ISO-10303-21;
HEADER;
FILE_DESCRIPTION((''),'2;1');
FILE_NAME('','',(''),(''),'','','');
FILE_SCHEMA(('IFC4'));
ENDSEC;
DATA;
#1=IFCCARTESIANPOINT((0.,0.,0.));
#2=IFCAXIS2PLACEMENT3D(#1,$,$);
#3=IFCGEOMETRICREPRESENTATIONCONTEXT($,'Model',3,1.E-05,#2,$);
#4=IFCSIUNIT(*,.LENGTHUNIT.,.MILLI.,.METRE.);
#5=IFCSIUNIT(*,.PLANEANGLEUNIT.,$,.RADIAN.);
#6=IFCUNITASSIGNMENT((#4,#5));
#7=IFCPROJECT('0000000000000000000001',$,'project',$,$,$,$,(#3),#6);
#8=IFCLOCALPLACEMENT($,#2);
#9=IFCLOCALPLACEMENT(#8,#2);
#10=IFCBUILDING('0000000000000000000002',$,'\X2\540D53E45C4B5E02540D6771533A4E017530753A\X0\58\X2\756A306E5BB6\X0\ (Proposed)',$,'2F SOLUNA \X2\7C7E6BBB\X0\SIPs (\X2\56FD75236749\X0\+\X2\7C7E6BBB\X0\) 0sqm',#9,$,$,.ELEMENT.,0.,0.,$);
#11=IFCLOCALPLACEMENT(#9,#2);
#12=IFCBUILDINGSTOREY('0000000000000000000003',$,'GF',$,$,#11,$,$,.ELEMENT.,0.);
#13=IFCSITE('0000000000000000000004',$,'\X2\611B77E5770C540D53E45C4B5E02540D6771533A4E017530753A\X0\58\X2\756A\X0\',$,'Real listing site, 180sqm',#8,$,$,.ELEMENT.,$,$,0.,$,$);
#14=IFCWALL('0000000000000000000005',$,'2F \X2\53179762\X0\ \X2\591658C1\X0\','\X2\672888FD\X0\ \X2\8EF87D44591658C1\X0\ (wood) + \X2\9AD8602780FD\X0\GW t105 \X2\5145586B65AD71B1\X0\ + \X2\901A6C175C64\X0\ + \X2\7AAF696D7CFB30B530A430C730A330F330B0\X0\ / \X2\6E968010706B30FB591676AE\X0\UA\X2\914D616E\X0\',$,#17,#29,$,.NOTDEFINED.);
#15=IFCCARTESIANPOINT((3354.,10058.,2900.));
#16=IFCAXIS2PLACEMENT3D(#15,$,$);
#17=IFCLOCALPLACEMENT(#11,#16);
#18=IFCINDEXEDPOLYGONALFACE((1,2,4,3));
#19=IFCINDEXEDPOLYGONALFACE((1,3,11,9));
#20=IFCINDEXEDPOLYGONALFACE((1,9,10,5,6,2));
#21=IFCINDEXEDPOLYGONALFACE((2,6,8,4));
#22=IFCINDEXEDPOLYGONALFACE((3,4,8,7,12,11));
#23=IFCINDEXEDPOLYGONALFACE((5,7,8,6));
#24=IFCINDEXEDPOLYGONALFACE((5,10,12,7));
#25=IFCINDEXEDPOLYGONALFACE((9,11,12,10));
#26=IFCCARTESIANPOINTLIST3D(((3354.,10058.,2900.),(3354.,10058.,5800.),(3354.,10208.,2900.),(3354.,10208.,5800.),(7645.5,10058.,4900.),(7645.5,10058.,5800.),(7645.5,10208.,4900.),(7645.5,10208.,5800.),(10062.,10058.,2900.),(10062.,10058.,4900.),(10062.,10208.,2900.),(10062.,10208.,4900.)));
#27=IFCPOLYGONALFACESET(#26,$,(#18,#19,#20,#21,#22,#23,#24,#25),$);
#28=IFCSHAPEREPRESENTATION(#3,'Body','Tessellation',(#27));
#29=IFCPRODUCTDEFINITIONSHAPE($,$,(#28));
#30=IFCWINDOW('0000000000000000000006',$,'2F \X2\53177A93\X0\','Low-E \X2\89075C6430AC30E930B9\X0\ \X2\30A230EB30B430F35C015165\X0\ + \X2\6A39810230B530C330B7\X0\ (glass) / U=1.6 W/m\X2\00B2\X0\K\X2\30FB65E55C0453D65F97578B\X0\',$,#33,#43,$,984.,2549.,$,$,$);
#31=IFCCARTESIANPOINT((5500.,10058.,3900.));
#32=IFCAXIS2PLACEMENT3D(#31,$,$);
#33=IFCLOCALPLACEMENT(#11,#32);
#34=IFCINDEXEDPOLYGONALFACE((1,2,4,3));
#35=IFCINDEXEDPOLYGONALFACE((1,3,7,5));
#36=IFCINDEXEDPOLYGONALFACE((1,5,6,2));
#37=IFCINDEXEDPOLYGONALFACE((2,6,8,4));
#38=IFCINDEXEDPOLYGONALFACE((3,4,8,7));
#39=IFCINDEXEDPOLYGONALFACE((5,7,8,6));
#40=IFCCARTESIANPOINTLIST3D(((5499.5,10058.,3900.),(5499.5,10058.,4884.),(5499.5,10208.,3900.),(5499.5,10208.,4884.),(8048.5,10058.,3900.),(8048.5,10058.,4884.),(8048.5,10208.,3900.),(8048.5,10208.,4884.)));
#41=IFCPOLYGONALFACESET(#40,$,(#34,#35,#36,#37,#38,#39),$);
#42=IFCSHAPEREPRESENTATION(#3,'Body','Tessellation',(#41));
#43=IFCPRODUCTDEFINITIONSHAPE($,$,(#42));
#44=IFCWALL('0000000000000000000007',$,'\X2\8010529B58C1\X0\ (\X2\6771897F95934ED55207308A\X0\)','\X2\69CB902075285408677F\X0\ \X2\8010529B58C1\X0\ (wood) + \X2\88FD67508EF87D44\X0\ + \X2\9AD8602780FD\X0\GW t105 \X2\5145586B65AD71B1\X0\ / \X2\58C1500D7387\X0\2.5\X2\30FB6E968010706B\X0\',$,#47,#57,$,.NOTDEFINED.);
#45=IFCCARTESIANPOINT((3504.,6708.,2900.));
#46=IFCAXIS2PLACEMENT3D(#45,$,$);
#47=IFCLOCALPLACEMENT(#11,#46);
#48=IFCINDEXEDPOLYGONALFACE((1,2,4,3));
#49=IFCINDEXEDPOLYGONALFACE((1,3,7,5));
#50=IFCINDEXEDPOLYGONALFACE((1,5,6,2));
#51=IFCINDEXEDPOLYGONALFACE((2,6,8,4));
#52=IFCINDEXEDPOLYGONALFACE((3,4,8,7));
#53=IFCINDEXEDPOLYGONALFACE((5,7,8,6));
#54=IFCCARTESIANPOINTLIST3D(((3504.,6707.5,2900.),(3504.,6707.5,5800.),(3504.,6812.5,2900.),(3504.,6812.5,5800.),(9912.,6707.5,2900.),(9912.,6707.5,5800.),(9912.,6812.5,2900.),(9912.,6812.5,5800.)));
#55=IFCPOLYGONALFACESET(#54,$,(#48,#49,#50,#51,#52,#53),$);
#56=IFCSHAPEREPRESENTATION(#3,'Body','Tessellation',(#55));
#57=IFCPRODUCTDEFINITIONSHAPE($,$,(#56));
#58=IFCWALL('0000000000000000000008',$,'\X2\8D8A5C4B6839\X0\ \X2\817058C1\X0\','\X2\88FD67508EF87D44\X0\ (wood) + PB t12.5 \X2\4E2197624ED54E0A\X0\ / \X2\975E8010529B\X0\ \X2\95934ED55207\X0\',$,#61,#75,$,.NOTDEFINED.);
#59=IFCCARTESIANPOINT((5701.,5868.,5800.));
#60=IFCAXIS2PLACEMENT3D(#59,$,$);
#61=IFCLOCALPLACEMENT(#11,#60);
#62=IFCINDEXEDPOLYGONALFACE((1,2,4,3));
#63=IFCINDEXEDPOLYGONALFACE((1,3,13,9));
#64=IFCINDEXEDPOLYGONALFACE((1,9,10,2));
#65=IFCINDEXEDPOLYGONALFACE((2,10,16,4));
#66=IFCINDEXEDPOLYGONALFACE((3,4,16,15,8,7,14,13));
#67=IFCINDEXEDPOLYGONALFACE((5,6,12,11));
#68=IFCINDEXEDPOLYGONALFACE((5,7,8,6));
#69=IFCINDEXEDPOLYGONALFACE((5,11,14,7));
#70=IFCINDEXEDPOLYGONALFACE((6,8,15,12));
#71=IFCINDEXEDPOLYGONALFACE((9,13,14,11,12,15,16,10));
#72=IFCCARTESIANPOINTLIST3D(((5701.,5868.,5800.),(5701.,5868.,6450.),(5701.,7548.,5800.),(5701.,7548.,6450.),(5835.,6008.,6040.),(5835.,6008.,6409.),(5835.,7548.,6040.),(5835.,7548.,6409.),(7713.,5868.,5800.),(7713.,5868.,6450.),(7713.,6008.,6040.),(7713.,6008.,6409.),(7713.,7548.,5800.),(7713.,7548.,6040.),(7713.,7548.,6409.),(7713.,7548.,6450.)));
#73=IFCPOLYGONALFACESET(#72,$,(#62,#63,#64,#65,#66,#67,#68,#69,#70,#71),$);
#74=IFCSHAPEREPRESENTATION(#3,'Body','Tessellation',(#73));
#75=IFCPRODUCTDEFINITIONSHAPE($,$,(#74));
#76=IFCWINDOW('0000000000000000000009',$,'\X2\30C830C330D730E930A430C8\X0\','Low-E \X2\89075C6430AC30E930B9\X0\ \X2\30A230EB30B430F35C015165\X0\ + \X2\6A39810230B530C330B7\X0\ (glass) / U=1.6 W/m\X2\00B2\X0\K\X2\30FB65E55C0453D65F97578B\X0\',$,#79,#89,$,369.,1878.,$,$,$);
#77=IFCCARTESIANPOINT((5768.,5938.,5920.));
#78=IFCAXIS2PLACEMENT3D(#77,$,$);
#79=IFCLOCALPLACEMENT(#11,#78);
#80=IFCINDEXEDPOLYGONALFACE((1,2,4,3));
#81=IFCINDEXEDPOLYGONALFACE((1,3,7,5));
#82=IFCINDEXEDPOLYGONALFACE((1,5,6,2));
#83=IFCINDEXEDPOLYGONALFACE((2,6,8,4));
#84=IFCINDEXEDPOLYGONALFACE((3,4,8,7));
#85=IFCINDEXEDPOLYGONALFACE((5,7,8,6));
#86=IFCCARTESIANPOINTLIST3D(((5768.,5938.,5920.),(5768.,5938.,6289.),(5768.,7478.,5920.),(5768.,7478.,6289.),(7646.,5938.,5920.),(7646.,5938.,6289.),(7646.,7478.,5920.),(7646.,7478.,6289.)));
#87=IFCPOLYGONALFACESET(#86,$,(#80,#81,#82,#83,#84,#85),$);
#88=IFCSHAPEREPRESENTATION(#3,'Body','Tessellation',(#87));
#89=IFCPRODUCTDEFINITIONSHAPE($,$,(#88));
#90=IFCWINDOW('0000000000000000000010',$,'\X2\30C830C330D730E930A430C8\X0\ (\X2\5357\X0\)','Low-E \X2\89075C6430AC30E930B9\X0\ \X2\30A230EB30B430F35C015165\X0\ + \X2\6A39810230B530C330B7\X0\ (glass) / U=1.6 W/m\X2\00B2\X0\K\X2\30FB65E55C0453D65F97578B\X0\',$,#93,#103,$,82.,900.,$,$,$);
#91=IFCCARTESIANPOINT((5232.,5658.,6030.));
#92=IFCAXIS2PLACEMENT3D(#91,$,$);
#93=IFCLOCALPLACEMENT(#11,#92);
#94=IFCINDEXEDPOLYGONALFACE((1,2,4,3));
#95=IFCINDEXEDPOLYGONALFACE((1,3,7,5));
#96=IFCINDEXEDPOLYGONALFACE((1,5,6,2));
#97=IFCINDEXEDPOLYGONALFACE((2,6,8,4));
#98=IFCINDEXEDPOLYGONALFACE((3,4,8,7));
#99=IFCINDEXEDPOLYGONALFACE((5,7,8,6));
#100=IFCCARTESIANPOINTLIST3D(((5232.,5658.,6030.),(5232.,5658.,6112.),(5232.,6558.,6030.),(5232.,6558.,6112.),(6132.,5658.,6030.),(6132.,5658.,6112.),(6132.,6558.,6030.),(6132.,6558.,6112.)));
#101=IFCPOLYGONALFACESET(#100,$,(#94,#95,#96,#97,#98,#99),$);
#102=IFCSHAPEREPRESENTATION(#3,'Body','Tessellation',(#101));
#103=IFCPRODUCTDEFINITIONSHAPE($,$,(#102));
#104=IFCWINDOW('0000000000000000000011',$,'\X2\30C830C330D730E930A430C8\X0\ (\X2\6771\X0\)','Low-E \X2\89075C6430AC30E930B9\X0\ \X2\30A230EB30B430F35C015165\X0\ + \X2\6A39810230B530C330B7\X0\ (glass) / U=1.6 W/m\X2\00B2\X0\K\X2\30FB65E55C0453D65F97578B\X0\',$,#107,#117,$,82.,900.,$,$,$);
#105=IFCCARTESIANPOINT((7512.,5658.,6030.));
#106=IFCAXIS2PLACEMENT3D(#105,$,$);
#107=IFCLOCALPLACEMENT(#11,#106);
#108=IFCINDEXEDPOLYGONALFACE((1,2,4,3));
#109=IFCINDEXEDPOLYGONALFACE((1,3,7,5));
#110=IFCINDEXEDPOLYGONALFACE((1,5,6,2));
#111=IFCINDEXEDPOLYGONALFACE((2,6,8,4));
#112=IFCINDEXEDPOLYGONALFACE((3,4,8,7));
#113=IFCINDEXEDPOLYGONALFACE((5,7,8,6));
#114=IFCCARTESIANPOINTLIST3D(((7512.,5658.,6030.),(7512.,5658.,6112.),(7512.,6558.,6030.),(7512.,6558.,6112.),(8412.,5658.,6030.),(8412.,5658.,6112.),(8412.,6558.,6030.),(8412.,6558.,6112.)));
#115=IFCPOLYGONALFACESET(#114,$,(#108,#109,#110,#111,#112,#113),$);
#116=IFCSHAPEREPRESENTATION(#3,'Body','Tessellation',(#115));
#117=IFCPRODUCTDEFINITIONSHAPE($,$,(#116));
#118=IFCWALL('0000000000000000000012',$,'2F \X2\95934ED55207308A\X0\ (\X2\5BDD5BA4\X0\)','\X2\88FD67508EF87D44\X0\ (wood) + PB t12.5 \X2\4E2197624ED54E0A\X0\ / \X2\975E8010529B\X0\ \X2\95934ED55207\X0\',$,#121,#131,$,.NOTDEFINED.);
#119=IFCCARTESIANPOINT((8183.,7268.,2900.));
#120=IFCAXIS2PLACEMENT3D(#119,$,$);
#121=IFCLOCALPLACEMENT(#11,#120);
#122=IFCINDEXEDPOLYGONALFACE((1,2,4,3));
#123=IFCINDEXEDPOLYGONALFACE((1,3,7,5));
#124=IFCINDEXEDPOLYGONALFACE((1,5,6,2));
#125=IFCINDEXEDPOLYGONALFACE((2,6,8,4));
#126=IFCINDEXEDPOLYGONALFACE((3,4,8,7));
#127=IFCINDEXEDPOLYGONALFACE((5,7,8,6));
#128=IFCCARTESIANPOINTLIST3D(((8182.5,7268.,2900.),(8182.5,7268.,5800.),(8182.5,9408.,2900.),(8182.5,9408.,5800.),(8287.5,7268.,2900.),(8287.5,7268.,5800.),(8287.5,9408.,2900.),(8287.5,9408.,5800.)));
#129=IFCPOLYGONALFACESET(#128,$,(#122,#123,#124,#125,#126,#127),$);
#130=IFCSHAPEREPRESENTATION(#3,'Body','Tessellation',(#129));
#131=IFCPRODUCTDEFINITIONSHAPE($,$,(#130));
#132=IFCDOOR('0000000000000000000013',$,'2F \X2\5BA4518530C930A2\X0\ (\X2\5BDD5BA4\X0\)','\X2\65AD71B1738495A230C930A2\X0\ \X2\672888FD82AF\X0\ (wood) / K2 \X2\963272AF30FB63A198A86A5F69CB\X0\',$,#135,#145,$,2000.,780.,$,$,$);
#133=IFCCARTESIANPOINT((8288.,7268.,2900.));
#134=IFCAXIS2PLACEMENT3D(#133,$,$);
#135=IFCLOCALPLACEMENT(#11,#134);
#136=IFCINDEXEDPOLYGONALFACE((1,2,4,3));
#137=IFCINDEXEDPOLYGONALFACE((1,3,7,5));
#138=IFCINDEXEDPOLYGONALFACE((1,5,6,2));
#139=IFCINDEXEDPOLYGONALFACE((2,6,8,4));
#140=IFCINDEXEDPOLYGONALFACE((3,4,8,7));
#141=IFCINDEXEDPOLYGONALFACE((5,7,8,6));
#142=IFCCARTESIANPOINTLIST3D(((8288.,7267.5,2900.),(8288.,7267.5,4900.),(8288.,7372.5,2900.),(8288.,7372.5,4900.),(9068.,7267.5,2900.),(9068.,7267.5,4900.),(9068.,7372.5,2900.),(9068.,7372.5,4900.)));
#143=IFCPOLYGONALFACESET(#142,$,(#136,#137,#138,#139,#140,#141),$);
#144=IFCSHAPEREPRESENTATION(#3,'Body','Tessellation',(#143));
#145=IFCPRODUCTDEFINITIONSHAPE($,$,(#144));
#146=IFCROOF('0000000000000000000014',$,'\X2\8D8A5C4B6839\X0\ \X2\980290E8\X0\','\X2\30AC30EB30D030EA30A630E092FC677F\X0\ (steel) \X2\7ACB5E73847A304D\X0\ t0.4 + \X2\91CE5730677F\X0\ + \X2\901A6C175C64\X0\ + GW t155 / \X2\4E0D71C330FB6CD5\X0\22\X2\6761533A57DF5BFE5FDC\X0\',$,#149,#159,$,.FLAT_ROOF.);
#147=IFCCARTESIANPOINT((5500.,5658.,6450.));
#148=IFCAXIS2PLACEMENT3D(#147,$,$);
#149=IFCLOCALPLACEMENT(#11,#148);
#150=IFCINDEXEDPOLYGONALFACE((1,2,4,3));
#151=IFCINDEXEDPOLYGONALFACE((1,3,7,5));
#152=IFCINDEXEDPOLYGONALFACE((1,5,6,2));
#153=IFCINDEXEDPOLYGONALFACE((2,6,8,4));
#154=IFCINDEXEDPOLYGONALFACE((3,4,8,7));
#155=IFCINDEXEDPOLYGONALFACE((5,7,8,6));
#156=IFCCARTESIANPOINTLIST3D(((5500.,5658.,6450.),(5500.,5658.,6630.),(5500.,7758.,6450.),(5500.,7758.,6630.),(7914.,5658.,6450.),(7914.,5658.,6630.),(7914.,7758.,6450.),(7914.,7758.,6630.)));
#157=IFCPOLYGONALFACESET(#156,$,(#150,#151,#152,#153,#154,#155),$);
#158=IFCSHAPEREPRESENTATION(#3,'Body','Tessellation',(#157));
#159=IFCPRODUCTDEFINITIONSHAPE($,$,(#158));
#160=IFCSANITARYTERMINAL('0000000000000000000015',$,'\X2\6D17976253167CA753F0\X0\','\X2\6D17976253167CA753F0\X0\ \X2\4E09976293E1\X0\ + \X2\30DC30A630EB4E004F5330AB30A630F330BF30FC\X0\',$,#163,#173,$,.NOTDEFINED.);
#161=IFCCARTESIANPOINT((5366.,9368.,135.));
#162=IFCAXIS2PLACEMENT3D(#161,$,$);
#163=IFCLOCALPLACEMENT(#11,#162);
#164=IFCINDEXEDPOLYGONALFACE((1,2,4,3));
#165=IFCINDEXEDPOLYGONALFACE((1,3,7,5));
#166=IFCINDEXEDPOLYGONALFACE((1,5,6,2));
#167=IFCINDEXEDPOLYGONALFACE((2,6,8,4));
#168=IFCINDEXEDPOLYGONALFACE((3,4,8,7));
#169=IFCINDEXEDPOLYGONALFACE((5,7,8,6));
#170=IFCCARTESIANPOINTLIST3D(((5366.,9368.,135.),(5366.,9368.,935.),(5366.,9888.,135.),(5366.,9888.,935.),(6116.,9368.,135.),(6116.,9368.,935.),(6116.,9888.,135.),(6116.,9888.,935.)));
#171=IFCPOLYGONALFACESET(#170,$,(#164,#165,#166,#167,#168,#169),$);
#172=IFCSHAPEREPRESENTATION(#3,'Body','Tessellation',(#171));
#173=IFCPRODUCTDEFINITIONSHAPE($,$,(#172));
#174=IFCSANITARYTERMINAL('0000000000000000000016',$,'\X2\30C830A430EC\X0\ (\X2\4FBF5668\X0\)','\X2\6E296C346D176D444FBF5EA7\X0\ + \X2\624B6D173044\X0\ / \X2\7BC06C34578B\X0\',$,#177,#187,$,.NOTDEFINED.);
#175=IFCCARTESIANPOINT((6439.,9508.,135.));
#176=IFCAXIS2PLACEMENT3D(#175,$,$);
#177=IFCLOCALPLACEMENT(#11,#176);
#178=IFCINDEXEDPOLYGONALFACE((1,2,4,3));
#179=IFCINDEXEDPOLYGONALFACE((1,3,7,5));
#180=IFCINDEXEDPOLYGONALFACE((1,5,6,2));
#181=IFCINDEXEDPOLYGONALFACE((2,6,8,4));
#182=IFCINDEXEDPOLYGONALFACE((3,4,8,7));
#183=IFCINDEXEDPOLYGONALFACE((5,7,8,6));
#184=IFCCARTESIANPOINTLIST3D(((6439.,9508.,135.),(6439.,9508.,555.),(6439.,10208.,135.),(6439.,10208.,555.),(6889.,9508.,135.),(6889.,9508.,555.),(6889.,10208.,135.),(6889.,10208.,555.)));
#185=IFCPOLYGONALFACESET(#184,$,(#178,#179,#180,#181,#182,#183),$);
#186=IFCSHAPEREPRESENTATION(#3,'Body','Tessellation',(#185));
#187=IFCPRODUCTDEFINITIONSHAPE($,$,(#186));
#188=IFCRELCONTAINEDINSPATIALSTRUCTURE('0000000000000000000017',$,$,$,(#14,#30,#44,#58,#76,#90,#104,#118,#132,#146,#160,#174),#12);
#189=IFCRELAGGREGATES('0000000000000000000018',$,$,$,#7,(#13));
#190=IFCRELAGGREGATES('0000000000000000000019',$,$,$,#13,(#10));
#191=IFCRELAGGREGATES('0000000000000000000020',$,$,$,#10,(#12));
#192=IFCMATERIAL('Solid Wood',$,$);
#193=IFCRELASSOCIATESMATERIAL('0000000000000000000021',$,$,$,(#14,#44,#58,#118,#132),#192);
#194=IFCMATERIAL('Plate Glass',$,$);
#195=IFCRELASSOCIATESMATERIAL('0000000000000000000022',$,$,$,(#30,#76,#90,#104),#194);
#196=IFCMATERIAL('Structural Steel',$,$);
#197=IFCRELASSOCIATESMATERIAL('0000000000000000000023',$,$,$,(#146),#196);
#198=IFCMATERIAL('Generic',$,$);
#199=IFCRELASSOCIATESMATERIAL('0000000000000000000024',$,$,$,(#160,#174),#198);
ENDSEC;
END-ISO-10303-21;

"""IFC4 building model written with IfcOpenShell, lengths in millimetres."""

from ifc_helpers import new_model, si_unit, frame, frame_2d, origin, place, context, project, spatial, rectangle, extrude, material, element, fill, save


model = new_model("IFC4")

# Units and contexts
model_context = context("Model", 3, precision=1e-05, world=origin())
ifc_project = project(units=[si_unit("LENGTHUNIT", "METRE", prefix="MILLI"), si_unit("PLANEANGLEUNIT", "RADIAN")], contexts=[model_context])

# Site, building, storey
site_placement = place(None, origin())
site = spatial("IfcSite", under=ifc_project, at=site_placement, Name="愛知県名古屋市名東区丁田町58番", ObjectType="Real listing site, 180sqm", CompositionType="ELEMENT", RefElevation=0.0)
building_placement = place(site_placement, origin())
building = spatial("IfcBuilding", under=site, at=building_placement, Name="名古屋市名東区丁田町58番の家 (Proposed)", ObjectType="2F SOLUNA 籾殻SIPs (国産杉+籾殻) 0sqm", CompositionType="ELEMENT", ElevationOfRefHeight=0.0, ElevationOfTerrain=0.0)
storey_placement = place(building_placement, origin())
storey = spatial("IfcBuildingStorey", under=building, at=storey_placement, Name="GF", CompositionType="ELEMENT", Elevation=0.0)

# Wall, opening, window
ifc_material_1 = material(Name="Solid Wood")
wall_1_placement = place(storey_placement, frame((3354.0, 10058.0, 2900.0)))
wall_1 = element("IfcWall", 1, at=wall_1_placement, inside=storey, material=ifc_material_1, Name="2F 北面 外壁", Description="木製 軸組外壁 (wood) + 高性能GW t105 充填断熱 + 通気層 + 窯業系サイディング / 準耐火・外皮UA配慮", PredefinedType="NOTDEFINED", context=model_context, shape_type="SweptSolid", body=[
    extrude(rectangle(XDim=6708.0, YDim=150.0, at=frame_2d((3354.0, 75.0))), frame((3354.0, 10058.0, 2900.0)), (0.0, 0.0, 1.0), 2900.0),
])
opening_1_placement = place(storey_placement, frame((5500.0, 10058.0, 3900.0)))
opening_1 = element("IfcOpeningElement", 2, at=opening_1_placement, cuts=wall_1, PredefinedType="NOTDEFINED", context=model_context, shape_type="SweptSolid", body=[
    extrude(rectangle(XDim=2549.0, YDim=150.0, at=frame_2d((1274.0, 75.0))), frame((5500.0, 10058.0, 3900.0)), (0.0, 0.0, 1.0), 984.0),
])
ifc_material_2 = material(Name="Plate Glass")
window_1_placement = place(storey_placement, frame((5500.0, 10058.0, 3900.0)))
window_1 = element("IfcWindow", 3, at=window_1_placement, inside=storey, material=ifc_material_2, Name="2F 北窓", Description="Low-E 複層ガラス アルゴン封入 + 樹脂サッシ (glass) / U=1.6 W/m²K・日射取得型", OverallHeight=984.0, OverallWidth=2549.0, context=model_context, shape_type="SweptSolid", body=[
    extrude(rectangle(XDim=2549.0, YDim=150.0, at=frame_2d((1274.0, 75.0))), frame((5500.0, 10058.0, 3900.0)), (0.0, 0.0, 1.0), 984.0),
])
fill(opening_1, window_1)

# Wall
wall_2_placement = place(storey_placement, frame((3504.0, 6708.0, 2900.0)))
element("IfcWall", 4, at=wall_2_placement, inside=storey, material=ifc_material_1, Name="耐力壁 (東西間仕切り)", Description="構造用合板 耐力壁 (wood) + 製材軸組 + 高性能GW t105 充填断熱 / 壁倍率2.5・準耐火", PredefinedType="NOTDEFINED", context=model_context, shape_type="SweptSolid", body=[
    extrude(rectangle(XDim=6408.0, YDim=105.0, at=frame_2d((3204.0, 52.0))), frame((3504.0, 6708.0, 2900.0)), (0.0, 0.0, 1.0), 2900.0),
])

# Wall, openings, windows
wall_3_placement = place(storey_placement, frame((5701.0, 5868.0, 5800.0)))
wall_3 = element("IfcWall", 5, at=wall_3_placement, inside=storey, material=ifc_material_1, Name="越屋根 腰壁", Description="製材軸組 (wood) + PB t12.5 両面仕上 / 非耐力 間仕切", PredefinedType="NOTDEFINED", context=model_context, shape_type="SweptSolid", body=[
    extrude(rectangle(XDim=2012.0, YDim=1680.0, at=frame_2d((1006.0, 840.0))), frame((5701.0, 5868.0, 5800.0)), (0.0, 0.0, 1.0), 650.0),
])
opening_2_placement = place(storey_placement, frame((5768.0, 5938.0, 5920.0)))
opening_2 = element("IfcOpeningElement", 6, at=opening_2_placement, cuts=wall_3, PredefinedType="NOTDEFINED", context=model_context, shape_type="SweptSolid", body=[
    extrude(rectangle(XDim=1878.0, YDim=1540.0, at=frame_2d((939.0, 770.0))), frame((5768.0, 5938.0, 5920.0)), (0.0, 0.0, 1.0), 369.0),
])
opening_3_placement = place(storey_placement, frame((5232.0, 5658.0, 6030.0)))
opening_3 = element("IfcOpeningElement", 7, at=opening_3_placement, cuts=wall_3, PredefinedType="NOTDEFINED", context=model_context, shape_type="SweptSolid", body=[
    extrude(rectangle(XDim=900.0, YDim=900.0, at=frame_2d((450.0, 450.0))), frame((5232.0, 5658.0, 6030.0)), (0.0, 0.0, 1.0), 82.0),
])
opening_4_placement = place(storey_placement, frame((7512.0, 5658.0, 6030.0)))
opening_4 = element("IfcOpeningElement", 8, at=opening_4_placement, cuts=wall_3, PredefinedType="NOTDEFINED", context=model_context, shape_type="SweptSolid", body=[
    extrude(rectangle(XDim=900.0, YDim=900.0, at=frame_2d((450.0, 450.0))), frame((7512.0, 5658.0, 6030.0)), (0.0, 0.0, 1.0), 82.0),
])
window_2_placement = place(storey_placement, frame((5768.0, 5938.0, 5920.0)))
window_2 = element("IfcWindow", 9, at=window_2_placement, inside=storey, material=ifc_material_2, Name="トップライト", Description="Low-E 複層ガラス アルゴン封入 + 樹脂サッシ (glass) / U=1.6 W/m²K・日射取得型", OverallHeight=369.0, OverallWidth=1878.0, context=model_context, shape_type="SweptSolid", body=[
    extrude(rectangle(XDim=1878.0, YDim=1540.0, at=frame_2d((939.0, 770.0))), frame((5768.0, 5938.0, 5920.0)), (0.0, 0.0, 1.0), 369.0),
])
fill(opening_2, window_2)
window_3_placement = place(storey_placement, frame((5232.0, 5658.0, 6030.0)))
window_3 = element("IfcWindow", 10, at=window_3_placement, inside=storey, material=ifc_material_2, Name="トップライト (南)", Description="Low-E 複層ガラス アルゴン封入 + 樹脂サッシ (glass) / U=1.6 W/m²K・日射取得型", OverallHeight=82.0, OverallWidth=900.0, context=model_context, shape_type="SweptSolid", body=[
    extrude(rectangle(XDim=900.0, YDim=900.0, at=frame_2d((450.0, 450.0))), frame((5232.0, 5658.0, 6030.0)), (0.0, 0.0, 1.0), 82.0),
])
fill(opening_3, window_3)
window_4_placement = place(storey_placement, frame((7512.0, 5658.0, 6030.0)))
window_4 = element("IfcWindow", 11, at=window_4_placement, inside=storey, material=ifc_material_2, Name="トップライト (東)", Description="Low-E 複層ガラス アルゴン封入 + 樹脂サッシ (glass) / U=1.6 W/m²K・日射取得型", OverallHeight=82.0, OverallWidth=900.0, context=model_context, shape_type="SweptSolid", body=[
    extrude(rectangle(XDim=900.0, YDim=900.0, at=frame_2d((450.0, 450.0))), frame((7512.0, 5658.0, 6030.0)), (0.0, 0.0, 1.0), 82.0),
])
fill(opening_4, window_4)

# Wall
wall_4_placement = place(storey_placement, frame((8183.0, 7268.0, 2900.0)))
element("IfcWall", 12, at=wall_4_placement, inside=storey, material=ifc_material_1, Name="2F 間仕切り (寝室)", Description="製材軸組 (wood) + PB t12.5 両面仕上 / 非耐力 間仕切", PredefinedType="NOTDEFINED", context=model_context, shape_type="SweptSolid", body=[
    extrude(rectangle(XDim=105.0, YDim=2140.0, at=frame_2d((52.0, 1070.0))), frame((8183.0, 7268.0, 2900.0)), (0.0, 0.0, 1.0), 2900.0),
])

# Door
door_placement = place(storey_placement, frame((8288.0, 7268.0, 2900.0)))
element("IfcDoor", 13, at=door_placement, inside=storey, material=ifc_material_1, Name="2F 室内ドア (寝室)", Description="断熱玄関ドア 木製芯 (wood) / K2 防犯・採風機構", OverallHeight=2000.0, OverallWidth=780.0, context=model_context, shape_type="SweptSolid", body=[
    extrude(rectangle(XDim=780.0, YDim=105.0, at=frame_2d((390.0, 52.0))), frame((8288.0, 7268.0, 2900.0)), (0.0, 0.0, 1.0), 2000.0),
])

# Roof
ifc_material_3 = material(Name="Structural Steel")
roof_placement = place(storey_placement, frame((5500.0, 5658.0, 6450.0)))
element("IfcRoof", 14, at=roof_placement, inside=storey, material=ifc_material_3, Name="越屋根 頂部", Description="ガルバリウム鋼板 (steel) 立平葺き t0.4 + 野地板 + 通気層 + GW t155 / 不燃・法22条区域対応", PredefinedType="FLAT_ROOF", context=model_context, shape_type="SweptSolid", body=[
    extrude(rectangle(XDim=2414.0, YDim=2100.0, at=frame_2d((1207.0, 1050.0))), frame((5500.0, 5658.0, 6450.0)), (0.0, 0.0, 1.0), 180.0),
])

# Sanitary terminals
ifc_material_4 = material(Name="Generic")
sanitary_terminal_1_placement = place(storey_placement, frame((5366.0, 9368.0, 135.0)))
element("IfcSanitaryTerminal", 15, at=sanitary_terminal_1_placement, inside=storey, material=ifc_material_4, Name="洗面化粧台", Description="洗面化粧台 三面鏡 + ボウル一体カウンター", PredefinedType="NOTDEFINED", context=model_context, shape_type="SweptSolid", body=[
    extrude(rectangle(XDim=750.0, YDim=520.0, at=frame_2d((375.0, 260.0))), frame((5366.0, 9368.0, 135.0)), (0.0, 0.0, 1.0), 800.0),
])
sanitary_terminal_2_placement = place(storey_placement, frame((6439.0, 9508.0, 135.0)))
element("IfcSanitaryTerminal", 16, at=sanitary_terminal_2_placement, inside=storey, material=ifc_material_4, Name="トイレ (便器)", Description="温水洗浄便座 + 手洗い / 節水型", PredefinedType="NOTDEFINED", context=model_context, shape_type="SweptSolid", body=[
    extrude(rectangle(XDim=450.0, YDim=700.0, at=frame_2d((225.0, 350.0))), frame((6439.0, 9508.0, 135.0)), (0.0, 0.0, 1.0), 420.0),
])

save(model, "model.ifc")
